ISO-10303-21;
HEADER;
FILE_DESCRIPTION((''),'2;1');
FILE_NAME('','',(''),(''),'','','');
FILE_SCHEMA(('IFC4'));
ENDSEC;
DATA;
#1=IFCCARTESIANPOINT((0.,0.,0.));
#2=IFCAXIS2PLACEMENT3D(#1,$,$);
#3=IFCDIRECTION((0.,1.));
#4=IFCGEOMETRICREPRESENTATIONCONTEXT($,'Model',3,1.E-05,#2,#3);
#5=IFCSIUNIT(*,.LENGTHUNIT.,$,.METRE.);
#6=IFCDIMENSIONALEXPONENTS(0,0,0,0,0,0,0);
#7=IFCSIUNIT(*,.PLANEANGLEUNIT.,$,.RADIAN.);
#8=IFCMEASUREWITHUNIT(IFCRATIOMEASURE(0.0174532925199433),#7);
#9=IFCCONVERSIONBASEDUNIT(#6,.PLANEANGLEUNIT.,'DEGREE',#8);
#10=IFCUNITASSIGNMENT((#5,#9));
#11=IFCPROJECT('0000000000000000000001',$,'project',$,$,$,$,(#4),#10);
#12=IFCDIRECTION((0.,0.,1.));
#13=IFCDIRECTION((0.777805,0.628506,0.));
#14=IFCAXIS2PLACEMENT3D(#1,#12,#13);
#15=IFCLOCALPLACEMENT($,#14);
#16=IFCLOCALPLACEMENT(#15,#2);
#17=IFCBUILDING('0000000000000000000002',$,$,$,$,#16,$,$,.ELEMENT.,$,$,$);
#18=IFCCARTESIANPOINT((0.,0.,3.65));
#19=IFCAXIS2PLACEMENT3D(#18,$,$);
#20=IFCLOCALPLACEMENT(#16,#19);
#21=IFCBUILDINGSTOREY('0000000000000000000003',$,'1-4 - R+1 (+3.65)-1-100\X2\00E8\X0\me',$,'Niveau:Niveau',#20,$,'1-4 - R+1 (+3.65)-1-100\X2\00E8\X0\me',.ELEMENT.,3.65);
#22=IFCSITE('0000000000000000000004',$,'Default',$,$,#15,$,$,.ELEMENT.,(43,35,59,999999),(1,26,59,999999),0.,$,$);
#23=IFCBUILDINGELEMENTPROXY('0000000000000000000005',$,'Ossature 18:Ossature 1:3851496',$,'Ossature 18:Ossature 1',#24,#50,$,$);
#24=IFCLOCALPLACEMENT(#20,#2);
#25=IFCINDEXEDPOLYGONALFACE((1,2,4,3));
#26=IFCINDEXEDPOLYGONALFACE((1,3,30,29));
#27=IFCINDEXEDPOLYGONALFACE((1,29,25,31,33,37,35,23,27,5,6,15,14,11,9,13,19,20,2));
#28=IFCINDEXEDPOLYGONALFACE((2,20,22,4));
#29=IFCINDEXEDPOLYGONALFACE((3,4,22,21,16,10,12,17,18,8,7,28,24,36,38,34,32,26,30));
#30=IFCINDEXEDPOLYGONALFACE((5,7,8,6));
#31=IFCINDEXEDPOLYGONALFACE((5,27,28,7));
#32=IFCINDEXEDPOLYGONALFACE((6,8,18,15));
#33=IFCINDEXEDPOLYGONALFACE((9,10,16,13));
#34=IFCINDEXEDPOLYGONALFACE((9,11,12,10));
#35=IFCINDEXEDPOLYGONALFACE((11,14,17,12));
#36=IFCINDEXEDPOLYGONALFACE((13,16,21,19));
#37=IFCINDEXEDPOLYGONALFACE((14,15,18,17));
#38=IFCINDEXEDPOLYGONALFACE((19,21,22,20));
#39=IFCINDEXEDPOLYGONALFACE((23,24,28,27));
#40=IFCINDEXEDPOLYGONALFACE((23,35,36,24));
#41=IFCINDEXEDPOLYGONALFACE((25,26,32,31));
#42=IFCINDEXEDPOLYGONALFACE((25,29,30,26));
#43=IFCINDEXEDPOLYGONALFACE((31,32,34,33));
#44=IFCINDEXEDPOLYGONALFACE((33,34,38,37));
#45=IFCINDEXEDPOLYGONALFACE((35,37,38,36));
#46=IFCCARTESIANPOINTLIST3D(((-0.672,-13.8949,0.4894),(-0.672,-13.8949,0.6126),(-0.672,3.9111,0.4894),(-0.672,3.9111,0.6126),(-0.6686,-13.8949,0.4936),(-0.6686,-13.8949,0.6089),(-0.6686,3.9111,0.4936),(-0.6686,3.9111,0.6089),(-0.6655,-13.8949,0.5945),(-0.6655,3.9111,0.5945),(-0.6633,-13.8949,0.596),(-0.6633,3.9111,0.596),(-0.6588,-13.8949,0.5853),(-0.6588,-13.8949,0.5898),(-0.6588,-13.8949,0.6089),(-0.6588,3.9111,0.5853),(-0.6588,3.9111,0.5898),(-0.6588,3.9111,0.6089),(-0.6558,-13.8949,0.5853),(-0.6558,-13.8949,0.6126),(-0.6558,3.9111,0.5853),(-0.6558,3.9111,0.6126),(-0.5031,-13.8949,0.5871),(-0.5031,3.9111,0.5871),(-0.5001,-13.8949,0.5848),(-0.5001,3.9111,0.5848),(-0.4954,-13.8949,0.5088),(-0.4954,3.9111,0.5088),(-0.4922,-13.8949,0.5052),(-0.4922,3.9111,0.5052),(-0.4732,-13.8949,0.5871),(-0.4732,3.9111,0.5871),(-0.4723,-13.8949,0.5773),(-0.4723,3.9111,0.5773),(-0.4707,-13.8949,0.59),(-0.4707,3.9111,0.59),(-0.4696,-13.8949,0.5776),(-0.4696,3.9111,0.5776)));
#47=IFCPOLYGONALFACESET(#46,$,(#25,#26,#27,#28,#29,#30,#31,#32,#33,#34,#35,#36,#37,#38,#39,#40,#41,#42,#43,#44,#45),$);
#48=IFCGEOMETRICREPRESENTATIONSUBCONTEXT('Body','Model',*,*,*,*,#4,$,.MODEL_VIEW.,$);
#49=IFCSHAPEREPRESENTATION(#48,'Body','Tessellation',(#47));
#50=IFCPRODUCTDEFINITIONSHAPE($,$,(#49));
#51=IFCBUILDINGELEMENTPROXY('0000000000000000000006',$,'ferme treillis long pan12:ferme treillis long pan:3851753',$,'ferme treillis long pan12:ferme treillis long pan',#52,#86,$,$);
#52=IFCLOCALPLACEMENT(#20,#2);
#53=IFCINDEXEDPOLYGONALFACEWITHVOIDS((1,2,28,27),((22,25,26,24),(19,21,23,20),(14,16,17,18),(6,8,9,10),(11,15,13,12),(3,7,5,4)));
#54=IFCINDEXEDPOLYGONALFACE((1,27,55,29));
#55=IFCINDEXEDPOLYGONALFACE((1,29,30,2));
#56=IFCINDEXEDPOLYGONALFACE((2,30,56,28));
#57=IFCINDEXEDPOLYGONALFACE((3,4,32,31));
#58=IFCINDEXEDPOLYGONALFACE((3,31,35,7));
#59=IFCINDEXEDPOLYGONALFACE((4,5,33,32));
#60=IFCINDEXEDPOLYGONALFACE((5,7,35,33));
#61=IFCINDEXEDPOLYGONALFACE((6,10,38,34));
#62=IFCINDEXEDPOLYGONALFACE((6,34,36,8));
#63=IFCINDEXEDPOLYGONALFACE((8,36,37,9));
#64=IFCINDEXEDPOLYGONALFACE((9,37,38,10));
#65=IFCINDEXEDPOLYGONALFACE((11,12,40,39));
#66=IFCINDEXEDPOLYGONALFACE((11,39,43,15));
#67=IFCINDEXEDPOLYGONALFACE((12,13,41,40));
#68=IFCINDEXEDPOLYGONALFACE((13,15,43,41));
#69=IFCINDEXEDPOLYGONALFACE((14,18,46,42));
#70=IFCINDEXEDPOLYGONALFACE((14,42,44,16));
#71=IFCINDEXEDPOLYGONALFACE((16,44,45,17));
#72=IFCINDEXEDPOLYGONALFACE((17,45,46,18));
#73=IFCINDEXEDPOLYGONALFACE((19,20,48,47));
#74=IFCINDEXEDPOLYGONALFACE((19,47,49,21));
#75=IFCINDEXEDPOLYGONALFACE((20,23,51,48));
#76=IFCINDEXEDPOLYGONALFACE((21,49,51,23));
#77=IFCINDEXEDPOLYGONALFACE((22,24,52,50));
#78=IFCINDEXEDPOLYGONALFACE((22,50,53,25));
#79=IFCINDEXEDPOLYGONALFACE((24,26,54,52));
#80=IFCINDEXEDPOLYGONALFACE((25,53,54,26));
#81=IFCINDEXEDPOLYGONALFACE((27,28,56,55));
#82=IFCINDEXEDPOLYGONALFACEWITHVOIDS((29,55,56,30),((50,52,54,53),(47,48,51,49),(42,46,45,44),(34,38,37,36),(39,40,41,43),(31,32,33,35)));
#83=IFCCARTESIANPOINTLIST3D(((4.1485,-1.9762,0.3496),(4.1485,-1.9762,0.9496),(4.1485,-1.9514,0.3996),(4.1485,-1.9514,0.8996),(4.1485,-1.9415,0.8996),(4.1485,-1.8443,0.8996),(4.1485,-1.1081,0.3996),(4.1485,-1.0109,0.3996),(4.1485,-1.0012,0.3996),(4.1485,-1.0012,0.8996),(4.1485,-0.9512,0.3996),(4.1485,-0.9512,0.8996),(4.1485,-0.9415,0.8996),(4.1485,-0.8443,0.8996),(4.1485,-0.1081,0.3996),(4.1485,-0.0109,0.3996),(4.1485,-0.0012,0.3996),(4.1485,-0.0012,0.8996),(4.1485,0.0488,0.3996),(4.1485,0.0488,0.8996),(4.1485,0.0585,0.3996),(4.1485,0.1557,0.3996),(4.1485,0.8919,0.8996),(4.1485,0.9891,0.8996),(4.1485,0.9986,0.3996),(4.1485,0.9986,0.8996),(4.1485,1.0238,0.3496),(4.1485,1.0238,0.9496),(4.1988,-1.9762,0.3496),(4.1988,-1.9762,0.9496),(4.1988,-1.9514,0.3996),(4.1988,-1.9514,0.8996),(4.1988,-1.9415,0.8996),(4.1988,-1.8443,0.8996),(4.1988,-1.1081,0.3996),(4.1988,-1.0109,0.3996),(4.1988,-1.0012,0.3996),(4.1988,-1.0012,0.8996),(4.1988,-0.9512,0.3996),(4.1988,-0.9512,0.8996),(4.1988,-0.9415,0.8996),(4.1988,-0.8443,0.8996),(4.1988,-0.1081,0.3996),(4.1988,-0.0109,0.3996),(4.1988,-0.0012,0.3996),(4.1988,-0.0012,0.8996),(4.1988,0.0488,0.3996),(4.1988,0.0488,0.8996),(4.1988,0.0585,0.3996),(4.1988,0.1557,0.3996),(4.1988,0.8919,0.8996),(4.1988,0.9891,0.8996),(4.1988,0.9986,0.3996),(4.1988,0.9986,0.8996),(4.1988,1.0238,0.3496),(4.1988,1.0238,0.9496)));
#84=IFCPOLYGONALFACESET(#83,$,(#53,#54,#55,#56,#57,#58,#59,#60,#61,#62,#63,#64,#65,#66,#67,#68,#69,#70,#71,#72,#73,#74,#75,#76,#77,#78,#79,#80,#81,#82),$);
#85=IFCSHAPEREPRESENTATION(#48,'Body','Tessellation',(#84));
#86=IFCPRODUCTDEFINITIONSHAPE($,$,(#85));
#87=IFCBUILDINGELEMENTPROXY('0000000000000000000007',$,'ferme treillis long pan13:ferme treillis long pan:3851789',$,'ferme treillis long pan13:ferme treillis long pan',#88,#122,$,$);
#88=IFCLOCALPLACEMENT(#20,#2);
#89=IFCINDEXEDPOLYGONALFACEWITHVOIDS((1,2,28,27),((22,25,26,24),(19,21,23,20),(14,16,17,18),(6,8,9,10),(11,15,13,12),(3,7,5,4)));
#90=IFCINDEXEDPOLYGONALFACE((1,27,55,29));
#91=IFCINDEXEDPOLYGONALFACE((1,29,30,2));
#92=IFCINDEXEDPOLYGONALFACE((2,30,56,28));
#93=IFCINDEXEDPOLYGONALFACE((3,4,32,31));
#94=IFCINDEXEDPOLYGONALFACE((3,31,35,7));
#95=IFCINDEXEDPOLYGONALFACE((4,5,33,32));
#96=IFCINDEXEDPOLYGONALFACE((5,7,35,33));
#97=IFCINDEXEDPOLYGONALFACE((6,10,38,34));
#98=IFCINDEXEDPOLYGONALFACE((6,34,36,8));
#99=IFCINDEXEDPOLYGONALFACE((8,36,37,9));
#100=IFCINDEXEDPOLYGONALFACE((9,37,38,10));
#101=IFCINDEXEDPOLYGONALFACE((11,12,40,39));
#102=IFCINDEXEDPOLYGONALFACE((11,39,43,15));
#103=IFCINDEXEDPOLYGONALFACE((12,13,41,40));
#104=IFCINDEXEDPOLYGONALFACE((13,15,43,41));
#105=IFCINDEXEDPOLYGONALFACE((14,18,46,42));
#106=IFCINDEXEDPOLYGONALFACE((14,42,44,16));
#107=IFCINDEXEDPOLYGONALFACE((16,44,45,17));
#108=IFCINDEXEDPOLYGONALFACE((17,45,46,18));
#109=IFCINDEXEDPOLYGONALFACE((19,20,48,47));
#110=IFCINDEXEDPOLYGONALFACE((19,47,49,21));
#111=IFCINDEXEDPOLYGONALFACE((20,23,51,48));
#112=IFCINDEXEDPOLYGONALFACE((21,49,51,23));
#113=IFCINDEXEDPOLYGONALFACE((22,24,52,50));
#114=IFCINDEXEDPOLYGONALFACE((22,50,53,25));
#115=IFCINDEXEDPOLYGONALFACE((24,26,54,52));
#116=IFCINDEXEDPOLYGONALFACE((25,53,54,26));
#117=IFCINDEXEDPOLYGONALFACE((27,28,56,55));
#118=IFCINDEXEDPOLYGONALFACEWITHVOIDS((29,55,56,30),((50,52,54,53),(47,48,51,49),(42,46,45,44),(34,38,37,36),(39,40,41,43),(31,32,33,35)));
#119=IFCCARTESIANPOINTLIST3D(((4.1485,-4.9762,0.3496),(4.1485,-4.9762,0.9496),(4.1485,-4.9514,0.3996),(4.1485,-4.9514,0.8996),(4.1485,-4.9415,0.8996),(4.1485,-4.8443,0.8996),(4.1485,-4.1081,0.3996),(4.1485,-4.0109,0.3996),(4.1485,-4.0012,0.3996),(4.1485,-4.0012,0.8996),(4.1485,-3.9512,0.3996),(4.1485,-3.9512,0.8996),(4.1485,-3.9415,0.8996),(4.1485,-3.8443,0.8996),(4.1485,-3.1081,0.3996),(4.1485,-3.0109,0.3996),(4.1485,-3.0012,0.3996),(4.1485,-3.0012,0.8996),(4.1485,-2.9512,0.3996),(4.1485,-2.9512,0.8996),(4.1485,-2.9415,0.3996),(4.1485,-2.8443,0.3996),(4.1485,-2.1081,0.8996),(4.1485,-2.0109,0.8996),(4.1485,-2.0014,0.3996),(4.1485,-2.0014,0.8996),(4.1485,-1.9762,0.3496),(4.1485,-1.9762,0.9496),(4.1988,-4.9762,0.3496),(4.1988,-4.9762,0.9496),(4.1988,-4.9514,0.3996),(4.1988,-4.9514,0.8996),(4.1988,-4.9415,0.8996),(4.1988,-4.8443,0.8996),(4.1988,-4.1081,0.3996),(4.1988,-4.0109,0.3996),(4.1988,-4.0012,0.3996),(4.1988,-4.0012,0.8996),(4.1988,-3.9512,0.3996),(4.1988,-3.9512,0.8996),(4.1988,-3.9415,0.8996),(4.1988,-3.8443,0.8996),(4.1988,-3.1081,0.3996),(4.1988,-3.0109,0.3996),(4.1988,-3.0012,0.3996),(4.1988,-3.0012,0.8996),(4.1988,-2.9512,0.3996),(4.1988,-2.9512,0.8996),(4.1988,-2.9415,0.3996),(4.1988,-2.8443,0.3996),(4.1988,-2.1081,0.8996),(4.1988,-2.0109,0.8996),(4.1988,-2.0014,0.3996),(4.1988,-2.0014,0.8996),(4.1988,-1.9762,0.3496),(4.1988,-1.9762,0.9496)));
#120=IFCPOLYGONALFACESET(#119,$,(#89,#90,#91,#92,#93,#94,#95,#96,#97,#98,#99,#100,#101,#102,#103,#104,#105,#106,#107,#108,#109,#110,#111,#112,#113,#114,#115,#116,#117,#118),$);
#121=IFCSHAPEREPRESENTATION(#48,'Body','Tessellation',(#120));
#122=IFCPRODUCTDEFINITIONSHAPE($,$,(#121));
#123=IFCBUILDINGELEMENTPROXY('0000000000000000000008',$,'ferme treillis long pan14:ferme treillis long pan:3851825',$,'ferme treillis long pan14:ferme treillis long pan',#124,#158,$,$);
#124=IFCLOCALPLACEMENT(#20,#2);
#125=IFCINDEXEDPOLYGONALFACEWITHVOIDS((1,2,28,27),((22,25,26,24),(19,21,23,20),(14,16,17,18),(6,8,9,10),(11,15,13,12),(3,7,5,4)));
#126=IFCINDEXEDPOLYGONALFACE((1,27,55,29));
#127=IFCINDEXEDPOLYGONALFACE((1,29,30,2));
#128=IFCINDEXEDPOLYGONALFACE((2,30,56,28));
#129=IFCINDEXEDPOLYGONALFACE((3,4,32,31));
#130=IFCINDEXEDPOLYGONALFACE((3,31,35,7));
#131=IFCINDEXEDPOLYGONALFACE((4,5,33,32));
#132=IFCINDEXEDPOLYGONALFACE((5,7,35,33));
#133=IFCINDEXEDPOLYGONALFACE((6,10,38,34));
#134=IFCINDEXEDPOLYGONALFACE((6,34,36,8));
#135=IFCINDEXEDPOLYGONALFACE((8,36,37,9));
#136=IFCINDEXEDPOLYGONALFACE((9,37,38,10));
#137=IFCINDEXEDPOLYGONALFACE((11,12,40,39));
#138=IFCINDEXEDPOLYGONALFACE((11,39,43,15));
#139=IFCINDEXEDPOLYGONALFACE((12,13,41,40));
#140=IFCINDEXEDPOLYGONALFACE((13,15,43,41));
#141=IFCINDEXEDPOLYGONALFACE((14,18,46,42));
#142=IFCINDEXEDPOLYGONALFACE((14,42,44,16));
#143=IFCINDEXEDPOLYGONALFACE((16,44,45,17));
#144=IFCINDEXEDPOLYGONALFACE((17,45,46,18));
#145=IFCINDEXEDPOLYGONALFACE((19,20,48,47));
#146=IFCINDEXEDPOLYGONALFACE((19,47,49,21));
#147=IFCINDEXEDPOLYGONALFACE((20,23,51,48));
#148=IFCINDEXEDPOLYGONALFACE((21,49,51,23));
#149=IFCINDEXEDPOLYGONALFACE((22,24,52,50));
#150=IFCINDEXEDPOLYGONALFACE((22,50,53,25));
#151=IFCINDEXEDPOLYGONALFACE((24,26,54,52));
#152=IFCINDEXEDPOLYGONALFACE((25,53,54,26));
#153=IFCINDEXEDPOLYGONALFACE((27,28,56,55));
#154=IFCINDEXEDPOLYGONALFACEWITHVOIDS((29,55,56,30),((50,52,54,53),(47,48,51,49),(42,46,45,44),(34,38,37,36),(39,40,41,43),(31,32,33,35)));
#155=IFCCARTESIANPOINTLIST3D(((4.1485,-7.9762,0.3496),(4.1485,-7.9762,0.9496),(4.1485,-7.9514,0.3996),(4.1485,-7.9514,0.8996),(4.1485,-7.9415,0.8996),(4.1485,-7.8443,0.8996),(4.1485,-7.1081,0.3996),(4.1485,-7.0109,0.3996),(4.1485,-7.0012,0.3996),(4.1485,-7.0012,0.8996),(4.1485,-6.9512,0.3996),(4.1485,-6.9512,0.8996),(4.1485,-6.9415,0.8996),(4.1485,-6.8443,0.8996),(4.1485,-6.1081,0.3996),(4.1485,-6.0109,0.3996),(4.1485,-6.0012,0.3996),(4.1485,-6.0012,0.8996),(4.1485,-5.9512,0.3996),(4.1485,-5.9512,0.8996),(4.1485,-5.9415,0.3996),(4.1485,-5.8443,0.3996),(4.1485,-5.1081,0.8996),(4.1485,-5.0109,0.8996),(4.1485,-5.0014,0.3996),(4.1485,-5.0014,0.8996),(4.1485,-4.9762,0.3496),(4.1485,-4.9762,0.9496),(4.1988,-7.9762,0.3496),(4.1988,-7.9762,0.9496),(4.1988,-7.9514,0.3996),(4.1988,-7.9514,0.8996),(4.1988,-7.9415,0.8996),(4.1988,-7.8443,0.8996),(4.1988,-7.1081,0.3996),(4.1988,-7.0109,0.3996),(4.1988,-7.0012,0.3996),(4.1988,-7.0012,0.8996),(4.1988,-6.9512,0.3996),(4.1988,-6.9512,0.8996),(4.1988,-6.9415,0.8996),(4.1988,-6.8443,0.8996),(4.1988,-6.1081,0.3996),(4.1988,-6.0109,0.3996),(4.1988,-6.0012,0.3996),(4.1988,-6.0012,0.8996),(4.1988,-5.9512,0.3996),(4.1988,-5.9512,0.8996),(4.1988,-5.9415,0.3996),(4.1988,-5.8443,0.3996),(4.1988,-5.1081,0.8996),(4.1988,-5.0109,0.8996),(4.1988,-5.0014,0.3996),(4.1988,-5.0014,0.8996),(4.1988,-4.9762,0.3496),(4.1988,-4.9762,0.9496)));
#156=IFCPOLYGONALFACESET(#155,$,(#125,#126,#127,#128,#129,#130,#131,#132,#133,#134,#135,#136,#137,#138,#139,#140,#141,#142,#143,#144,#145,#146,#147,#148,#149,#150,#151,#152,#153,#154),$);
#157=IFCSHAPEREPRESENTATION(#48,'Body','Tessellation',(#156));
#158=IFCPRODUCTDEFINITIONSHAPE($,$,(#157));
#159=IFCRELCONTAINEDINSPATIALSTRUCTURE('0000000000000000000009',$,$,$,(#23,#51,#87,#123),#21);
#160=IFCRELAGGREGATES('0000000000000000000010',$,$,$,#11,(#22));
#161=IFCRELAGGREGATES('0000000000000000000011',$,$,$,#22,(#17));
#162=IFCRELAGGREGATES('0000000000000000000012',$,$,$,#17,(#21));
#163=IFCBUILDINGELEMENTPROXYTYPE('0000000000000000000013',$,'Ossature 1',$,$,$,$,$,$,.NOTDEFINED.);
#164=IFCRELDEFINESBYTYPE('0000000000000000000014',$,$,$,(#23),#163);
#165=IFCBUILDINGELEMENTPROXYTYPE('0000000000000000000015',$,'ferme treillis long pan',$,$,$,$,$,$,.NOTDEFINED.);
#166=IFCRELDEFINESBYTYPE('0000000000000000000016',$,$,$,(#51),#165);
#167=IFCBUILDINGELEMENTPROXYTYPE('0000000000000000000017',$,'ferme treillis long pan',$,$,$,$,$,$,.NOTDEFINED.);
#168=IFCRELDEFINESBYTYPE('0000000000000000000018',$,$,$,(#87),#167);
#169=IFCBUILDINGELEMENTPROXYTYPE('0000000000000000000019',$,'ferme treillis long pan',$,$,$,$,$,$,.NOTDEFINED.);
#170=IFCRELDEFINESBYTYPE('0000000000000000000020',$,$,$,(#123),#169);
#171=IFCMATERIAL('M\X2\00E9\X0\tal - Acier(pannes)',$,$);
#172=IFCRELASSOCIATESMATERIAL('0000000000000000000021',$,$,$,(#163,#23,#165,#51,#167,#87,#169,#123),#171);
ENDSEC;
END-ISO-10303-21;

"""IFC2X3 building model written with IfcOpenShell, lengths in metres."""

from ifc_helpers import new_model, entity, si_unit, converted_unit, direction, frame, origin, place, context, subcontext, project, spatial, polyline, outline, extrude, source, transform, mapped, material, type_object, type_shapes, element, save


model = new_model("IFC2X3")

# Units and contexts
model_context = context("Model", 3, precision=1e-05, world=origin(), true_north=direction((0.0, 1.0)))
body_context = subcontext(model_context, "Body", "Model", "MODEL_VIEW")
ifc_project = project(units=[si_unit("LENGTHUNIT", "METRE"), converted_unit("PLANEANGLEUNIT", "DEGREE", entity("IfcRatioMeasure", 0.0174532925199433), si_unit("PLANEANGLEUNIT", "RADIAN"), dimensions=[0, 0, 0, 0, 0, 0, 0])], contexts=[model_context])

# Site, building, storey
site_placement = place(None, frame((0.0, 0.0, 0.0), z_axis=(0.0, 0.0, 1.0), x_axis=(0.777805, 0.628506, 0.0)))
site = spatial("IfcSite", under=ifc_project, at=site_placement, Name="Default", CompositionType="ELEMENT", RefLatitude=(43, 35, 59, 999999), RefLongitude=(1, 26, 59, 999999), RefElevation=0.0)
building_placement = place(site_placement, origin())
building = spatial("IfcBuilding", under=site, at=building_placement, CompositionType="ELEMENT")
storey_placement = place(building_placement, frame((0.0, 0.0, 3.65)))
storey = spatial("IfcBuildingStorey", under=building, at=storey_placement, Name="1-4 - R+1 (+3.65)-1-100ème", ObjectType="Niveau:Niveau", LongName="1-4 - R+1 (+3.65)-1-100ème", CompositionType="ELEMENT", Elevation=3.65)

# Building element proxies
ifc_material_1 = material(Name="Métal - Acier(pannes)")
building_element_proxy_type_1 = type_object("IfcBuildingElementProxyType", Name="Ossature 1", PredefinedType="NOTDEFINED", material=ifc_material_1)
shared_shape_1 = source(origin(), body_context, "Body", "SweptSolid", [
    extrude(outline(polyline([(-0.0897, -0.0763), (0.0909, -0.0763), (0.0801, 0.0464), (0.0639, 0.0449), (0.0663, 0.0178), (0.0694, 0.018), (0.0752, 0.0277), (0.073, 0.029), (0.069, 0.0224), (0.0673, 0.0415), (0.0771, 0.0423), (0.0872, -0.0725), (-0.0868, -0.0724), (-0.0859, 0.0063), (-0.1185, 0.0063), (-0.1184, -0.0061), (-0.1157, -0.0062), (-0.1157, 0.0037), (-0.0887, 0.0037), (-0.0897, -0.0763)])), frame((-0.5881, -13.8949, 4.2234), z_axis=(0.0, 1.0, 0.0), x_axis=(-0.996195, 0.0, -0.087156)), (0.0, 0.0, 1.0), 17.8059),
])
type_shapes(building_element_proxy_type_1, [shared_shape_1])
proxy_1_placement = place(storey_placement, frame((0.0, 0.0, -3.65)))
element("IfcBuildingElementProxy", 1, at=proxy_1_placement, inside=storey, type_object=building_element_proxy_type_1, material=ifc_material_1, Name="Ossature 18:Ossature 1:3851496", ObjectType="Ossature 18:Ossature 1", context=body_context, shape_type="MappedRepresentation", body=[
    mapped(shared_shape_1, transform((0.0, 0.0, 0.0), scale=1.0)),
])
building_element_proxy_type_2 = type_object("IfcBuildingElementProxyType", Name="ferme treillis long pan", PredefinedType="NOTDEFINED", material=ifc_material_1)
shared_shape_2 = source(origin(), body_context, "Body", "SweptSolid", [
    extrude(outline(polyline([(-0.3, -1.5), (0.3, -1.5), (0.3, 1.5), (-0.3, 1.5), (-0.3, -1.5)]), holes=[polyline([(-0.25, 1.4653), (-0.25, 1.4748), (0.25, 1.4748), (0.25, 0.6319), (-0.25, 1.4653)]), polyline([(0.25, -0.6319), (0.25, -1.4752), (-0.25, -1.4752), (-0.25, -1.4653), (0.25, -0.6319)]), polyline([(0.25, 0.5347), (0.25, 0.525), (-0.25, 0.525), (-0.25, 1.3681), (0.25, 0.5347)]), polyline([(0.25, 0.475), (0.25, 0.4653), (-0.25, -0.3681), (-0.25, 0.475), (0.25, 0.475)]), polyline([(0.25, -0.475), (-0.25, -0.475), (-0.25, -0.4653), (0.25, 0.3681), (0.25, -0.475)]), polyline([(0.25, -0.525), (0.25, -0.5347), (-0.25, -1.3681), (-0.25, -0.525), (0.25, -0.525)])]), frame((4.1485, -0.4762, 4.2996), z_axis=(1.0, 0.0, 0.0), x_axis=(0.0, 0.0, -1.0)), (0.0, 0.0, 1.0), 0.0503),
])
type_shapes(building_element_proxy_type_2, [shared_shape_2])
proxy_2_placement = place(storey_placement, frame((0.0, 0.0, -3.65)))
element("IfcBuildingElementProxy", 2, at=proxy_2_placement, inside=storey, type_object=building_element_proxy_type_2, material=ifc_material_1, Name="ferme treillis long pan12:ferme treillis long pan:3851753", ObjectType="ferme treillis long pan12:ferme treillis long pan", context=body_context, shape_type="MappedRepresentation", body=[
    mapped(shared_shape_2, transform((0.0, 0.0, 0.0), scale=1.0)),
])
building_element_proxy_type_3 = type_object("IfcBuildingElementProxyType", Name="ferme treillis long pan", PredefinedType="NOTDEFINED", material=ifc_material_1)
shared_shape_3 = source(origin(), body_context, "Body", "SweptSolid", [
    extrude(outline(polyline([(-0.3, -1.5), (0.3, -1.5), (0.3, 1.5), (-0.3, 1.5), (-0.3, -1.5)]), holes=[polyline([(-0.25, 1.4653), (-0.25, 1.4748), (0.25, 1.4748), (0.25, 0.6319), (-0.25, 1.4653)]), polyline([(0.25, -0.6319), (0.25, -1.4752), (-0.25, -1.4752), (-0.25, -1.4653), (0.25, -0.6319)]), polyline([(0.25, 0.5347), (0.25, 0.525), (-0.25, 0.525), (-0.25, 1.3681), (0.25, 0.5347)]), polyline([(0.25, 0.475), (0.25, 0.4653), (-0.25, -0.3681), (-0.25, 0.475), (0.25, 0.475)]), polyline([(0.25, -0.475), (-0.25, -0.475), (-0.25, -0.4653), (0.25, 0.3681), (0.25, -0.475)]), polyline([(0.25, -0.525), (0.25, -0.5347), (-0.25, -1.3681), (-0.25, -0.525), (0.25, -0.525)])]), frame((4.1485, -3.4762, 4.2996), z_axis=(1.0, 0.0, 0.0), x_axis=(0.0, 0.0, -1.0)), (0.0, 0.0, 1.0), 0.0503),
])
type_shapes(building_element_proxy_type_3, [shared_shape_3])
proxy_3_placement = place(storey_placement, frame((0.0, 0.0, -3.65)))
element("IfcBuildingElementProxy", 3, at=proxy_3_placement, inside=storey, type_object=building_element_proxy_type_3, material=ifc_material_1, Name="ferme treillis long pan13:ferme treillis long pan:3851789", ObjectType="ferme treillis long pan13:ferme treillis long pan", context=body_context, shape_type="MappedRepresentation", body=[
    mapped(shared_shape_3, transform((0.0, 0.0, 0.0), scale=1.0)),
])
building_element_proxy_type_4 = type_object("IfcBuildingElementProxyType", Name="ferme treillis long pan", PredefinedType="NOTDEFINED", material=ifc_material_1)
shared_shape_4 = source(origin(), body_context, "Body", "SweptSolid", [
    extrude(outline(polyline([(-0.3, -1.5), (0.3, -1.5), (0.3, 1.5), (-0.3, 1.5), (-0.3, -1.5)]), holes=[polyline([(-0.25, 1.4653), (-0.25, 1.4748), (0.25, 1.4748), (0.25, 0.6319), (-0.25, 1.4653)]), polyline([(0.25, -0.6319), (0.25, -1.4752), (-0.25, -1.4752), (-0.25, -1.4653), (0.25, -0.6319)]), polyline([(0.25, 0.5347), (0.25, 0.525), (-0.25, 0.525), (-0.25, 1.3681), (0.25, 0.5347)]), polyline([(0.25, 0.475), (0.25, 0.4653), (-0.25, -0.3681), (-0.25, 0.475), (0.25, 0.475)]), polyline([(0.25, -0.475), (-0.25, -0.475), (-0.25, -0.4653), (0.25, 0.3681), (0.25, -0.475)]), polyline([(0.25, -0.525), (0.25, -0.5347), (-0.25, -1.3681), (-0.25, -0.525), (0.25, -0.525)])]), frame((4.1485, -6.4762, 4.2996), z_axis=(1.0, 0.0, 0.0), x_axis=(0.0, 0.0, -1.0)), (0.0, 0.0, 1.0), 0.0503),
])
type_shapes(building_element_proxy_type_4, [shared_shape_4])
proxy_4_placement = place(storey_placement, frame((0.0, 0.0, -3.65)))
element("IfcBuildingElementProxy", 4, at=proxy_4_placement, inside=storey, type_object=building_element_proxy_type_4, material=ifc_material_1, Name="ferme treillis long pan14:ferme treillis long pan:3851825", ObjectType="ferme treillis long pan14:ferme treillis long pan", context=body_context, shape_type="MappedRepresentation", body=[
    mapped(shared_shape_4, transform((0.0, 0.0, 0.0), scale=1.0)),
])

save(model, "model.ifc")
